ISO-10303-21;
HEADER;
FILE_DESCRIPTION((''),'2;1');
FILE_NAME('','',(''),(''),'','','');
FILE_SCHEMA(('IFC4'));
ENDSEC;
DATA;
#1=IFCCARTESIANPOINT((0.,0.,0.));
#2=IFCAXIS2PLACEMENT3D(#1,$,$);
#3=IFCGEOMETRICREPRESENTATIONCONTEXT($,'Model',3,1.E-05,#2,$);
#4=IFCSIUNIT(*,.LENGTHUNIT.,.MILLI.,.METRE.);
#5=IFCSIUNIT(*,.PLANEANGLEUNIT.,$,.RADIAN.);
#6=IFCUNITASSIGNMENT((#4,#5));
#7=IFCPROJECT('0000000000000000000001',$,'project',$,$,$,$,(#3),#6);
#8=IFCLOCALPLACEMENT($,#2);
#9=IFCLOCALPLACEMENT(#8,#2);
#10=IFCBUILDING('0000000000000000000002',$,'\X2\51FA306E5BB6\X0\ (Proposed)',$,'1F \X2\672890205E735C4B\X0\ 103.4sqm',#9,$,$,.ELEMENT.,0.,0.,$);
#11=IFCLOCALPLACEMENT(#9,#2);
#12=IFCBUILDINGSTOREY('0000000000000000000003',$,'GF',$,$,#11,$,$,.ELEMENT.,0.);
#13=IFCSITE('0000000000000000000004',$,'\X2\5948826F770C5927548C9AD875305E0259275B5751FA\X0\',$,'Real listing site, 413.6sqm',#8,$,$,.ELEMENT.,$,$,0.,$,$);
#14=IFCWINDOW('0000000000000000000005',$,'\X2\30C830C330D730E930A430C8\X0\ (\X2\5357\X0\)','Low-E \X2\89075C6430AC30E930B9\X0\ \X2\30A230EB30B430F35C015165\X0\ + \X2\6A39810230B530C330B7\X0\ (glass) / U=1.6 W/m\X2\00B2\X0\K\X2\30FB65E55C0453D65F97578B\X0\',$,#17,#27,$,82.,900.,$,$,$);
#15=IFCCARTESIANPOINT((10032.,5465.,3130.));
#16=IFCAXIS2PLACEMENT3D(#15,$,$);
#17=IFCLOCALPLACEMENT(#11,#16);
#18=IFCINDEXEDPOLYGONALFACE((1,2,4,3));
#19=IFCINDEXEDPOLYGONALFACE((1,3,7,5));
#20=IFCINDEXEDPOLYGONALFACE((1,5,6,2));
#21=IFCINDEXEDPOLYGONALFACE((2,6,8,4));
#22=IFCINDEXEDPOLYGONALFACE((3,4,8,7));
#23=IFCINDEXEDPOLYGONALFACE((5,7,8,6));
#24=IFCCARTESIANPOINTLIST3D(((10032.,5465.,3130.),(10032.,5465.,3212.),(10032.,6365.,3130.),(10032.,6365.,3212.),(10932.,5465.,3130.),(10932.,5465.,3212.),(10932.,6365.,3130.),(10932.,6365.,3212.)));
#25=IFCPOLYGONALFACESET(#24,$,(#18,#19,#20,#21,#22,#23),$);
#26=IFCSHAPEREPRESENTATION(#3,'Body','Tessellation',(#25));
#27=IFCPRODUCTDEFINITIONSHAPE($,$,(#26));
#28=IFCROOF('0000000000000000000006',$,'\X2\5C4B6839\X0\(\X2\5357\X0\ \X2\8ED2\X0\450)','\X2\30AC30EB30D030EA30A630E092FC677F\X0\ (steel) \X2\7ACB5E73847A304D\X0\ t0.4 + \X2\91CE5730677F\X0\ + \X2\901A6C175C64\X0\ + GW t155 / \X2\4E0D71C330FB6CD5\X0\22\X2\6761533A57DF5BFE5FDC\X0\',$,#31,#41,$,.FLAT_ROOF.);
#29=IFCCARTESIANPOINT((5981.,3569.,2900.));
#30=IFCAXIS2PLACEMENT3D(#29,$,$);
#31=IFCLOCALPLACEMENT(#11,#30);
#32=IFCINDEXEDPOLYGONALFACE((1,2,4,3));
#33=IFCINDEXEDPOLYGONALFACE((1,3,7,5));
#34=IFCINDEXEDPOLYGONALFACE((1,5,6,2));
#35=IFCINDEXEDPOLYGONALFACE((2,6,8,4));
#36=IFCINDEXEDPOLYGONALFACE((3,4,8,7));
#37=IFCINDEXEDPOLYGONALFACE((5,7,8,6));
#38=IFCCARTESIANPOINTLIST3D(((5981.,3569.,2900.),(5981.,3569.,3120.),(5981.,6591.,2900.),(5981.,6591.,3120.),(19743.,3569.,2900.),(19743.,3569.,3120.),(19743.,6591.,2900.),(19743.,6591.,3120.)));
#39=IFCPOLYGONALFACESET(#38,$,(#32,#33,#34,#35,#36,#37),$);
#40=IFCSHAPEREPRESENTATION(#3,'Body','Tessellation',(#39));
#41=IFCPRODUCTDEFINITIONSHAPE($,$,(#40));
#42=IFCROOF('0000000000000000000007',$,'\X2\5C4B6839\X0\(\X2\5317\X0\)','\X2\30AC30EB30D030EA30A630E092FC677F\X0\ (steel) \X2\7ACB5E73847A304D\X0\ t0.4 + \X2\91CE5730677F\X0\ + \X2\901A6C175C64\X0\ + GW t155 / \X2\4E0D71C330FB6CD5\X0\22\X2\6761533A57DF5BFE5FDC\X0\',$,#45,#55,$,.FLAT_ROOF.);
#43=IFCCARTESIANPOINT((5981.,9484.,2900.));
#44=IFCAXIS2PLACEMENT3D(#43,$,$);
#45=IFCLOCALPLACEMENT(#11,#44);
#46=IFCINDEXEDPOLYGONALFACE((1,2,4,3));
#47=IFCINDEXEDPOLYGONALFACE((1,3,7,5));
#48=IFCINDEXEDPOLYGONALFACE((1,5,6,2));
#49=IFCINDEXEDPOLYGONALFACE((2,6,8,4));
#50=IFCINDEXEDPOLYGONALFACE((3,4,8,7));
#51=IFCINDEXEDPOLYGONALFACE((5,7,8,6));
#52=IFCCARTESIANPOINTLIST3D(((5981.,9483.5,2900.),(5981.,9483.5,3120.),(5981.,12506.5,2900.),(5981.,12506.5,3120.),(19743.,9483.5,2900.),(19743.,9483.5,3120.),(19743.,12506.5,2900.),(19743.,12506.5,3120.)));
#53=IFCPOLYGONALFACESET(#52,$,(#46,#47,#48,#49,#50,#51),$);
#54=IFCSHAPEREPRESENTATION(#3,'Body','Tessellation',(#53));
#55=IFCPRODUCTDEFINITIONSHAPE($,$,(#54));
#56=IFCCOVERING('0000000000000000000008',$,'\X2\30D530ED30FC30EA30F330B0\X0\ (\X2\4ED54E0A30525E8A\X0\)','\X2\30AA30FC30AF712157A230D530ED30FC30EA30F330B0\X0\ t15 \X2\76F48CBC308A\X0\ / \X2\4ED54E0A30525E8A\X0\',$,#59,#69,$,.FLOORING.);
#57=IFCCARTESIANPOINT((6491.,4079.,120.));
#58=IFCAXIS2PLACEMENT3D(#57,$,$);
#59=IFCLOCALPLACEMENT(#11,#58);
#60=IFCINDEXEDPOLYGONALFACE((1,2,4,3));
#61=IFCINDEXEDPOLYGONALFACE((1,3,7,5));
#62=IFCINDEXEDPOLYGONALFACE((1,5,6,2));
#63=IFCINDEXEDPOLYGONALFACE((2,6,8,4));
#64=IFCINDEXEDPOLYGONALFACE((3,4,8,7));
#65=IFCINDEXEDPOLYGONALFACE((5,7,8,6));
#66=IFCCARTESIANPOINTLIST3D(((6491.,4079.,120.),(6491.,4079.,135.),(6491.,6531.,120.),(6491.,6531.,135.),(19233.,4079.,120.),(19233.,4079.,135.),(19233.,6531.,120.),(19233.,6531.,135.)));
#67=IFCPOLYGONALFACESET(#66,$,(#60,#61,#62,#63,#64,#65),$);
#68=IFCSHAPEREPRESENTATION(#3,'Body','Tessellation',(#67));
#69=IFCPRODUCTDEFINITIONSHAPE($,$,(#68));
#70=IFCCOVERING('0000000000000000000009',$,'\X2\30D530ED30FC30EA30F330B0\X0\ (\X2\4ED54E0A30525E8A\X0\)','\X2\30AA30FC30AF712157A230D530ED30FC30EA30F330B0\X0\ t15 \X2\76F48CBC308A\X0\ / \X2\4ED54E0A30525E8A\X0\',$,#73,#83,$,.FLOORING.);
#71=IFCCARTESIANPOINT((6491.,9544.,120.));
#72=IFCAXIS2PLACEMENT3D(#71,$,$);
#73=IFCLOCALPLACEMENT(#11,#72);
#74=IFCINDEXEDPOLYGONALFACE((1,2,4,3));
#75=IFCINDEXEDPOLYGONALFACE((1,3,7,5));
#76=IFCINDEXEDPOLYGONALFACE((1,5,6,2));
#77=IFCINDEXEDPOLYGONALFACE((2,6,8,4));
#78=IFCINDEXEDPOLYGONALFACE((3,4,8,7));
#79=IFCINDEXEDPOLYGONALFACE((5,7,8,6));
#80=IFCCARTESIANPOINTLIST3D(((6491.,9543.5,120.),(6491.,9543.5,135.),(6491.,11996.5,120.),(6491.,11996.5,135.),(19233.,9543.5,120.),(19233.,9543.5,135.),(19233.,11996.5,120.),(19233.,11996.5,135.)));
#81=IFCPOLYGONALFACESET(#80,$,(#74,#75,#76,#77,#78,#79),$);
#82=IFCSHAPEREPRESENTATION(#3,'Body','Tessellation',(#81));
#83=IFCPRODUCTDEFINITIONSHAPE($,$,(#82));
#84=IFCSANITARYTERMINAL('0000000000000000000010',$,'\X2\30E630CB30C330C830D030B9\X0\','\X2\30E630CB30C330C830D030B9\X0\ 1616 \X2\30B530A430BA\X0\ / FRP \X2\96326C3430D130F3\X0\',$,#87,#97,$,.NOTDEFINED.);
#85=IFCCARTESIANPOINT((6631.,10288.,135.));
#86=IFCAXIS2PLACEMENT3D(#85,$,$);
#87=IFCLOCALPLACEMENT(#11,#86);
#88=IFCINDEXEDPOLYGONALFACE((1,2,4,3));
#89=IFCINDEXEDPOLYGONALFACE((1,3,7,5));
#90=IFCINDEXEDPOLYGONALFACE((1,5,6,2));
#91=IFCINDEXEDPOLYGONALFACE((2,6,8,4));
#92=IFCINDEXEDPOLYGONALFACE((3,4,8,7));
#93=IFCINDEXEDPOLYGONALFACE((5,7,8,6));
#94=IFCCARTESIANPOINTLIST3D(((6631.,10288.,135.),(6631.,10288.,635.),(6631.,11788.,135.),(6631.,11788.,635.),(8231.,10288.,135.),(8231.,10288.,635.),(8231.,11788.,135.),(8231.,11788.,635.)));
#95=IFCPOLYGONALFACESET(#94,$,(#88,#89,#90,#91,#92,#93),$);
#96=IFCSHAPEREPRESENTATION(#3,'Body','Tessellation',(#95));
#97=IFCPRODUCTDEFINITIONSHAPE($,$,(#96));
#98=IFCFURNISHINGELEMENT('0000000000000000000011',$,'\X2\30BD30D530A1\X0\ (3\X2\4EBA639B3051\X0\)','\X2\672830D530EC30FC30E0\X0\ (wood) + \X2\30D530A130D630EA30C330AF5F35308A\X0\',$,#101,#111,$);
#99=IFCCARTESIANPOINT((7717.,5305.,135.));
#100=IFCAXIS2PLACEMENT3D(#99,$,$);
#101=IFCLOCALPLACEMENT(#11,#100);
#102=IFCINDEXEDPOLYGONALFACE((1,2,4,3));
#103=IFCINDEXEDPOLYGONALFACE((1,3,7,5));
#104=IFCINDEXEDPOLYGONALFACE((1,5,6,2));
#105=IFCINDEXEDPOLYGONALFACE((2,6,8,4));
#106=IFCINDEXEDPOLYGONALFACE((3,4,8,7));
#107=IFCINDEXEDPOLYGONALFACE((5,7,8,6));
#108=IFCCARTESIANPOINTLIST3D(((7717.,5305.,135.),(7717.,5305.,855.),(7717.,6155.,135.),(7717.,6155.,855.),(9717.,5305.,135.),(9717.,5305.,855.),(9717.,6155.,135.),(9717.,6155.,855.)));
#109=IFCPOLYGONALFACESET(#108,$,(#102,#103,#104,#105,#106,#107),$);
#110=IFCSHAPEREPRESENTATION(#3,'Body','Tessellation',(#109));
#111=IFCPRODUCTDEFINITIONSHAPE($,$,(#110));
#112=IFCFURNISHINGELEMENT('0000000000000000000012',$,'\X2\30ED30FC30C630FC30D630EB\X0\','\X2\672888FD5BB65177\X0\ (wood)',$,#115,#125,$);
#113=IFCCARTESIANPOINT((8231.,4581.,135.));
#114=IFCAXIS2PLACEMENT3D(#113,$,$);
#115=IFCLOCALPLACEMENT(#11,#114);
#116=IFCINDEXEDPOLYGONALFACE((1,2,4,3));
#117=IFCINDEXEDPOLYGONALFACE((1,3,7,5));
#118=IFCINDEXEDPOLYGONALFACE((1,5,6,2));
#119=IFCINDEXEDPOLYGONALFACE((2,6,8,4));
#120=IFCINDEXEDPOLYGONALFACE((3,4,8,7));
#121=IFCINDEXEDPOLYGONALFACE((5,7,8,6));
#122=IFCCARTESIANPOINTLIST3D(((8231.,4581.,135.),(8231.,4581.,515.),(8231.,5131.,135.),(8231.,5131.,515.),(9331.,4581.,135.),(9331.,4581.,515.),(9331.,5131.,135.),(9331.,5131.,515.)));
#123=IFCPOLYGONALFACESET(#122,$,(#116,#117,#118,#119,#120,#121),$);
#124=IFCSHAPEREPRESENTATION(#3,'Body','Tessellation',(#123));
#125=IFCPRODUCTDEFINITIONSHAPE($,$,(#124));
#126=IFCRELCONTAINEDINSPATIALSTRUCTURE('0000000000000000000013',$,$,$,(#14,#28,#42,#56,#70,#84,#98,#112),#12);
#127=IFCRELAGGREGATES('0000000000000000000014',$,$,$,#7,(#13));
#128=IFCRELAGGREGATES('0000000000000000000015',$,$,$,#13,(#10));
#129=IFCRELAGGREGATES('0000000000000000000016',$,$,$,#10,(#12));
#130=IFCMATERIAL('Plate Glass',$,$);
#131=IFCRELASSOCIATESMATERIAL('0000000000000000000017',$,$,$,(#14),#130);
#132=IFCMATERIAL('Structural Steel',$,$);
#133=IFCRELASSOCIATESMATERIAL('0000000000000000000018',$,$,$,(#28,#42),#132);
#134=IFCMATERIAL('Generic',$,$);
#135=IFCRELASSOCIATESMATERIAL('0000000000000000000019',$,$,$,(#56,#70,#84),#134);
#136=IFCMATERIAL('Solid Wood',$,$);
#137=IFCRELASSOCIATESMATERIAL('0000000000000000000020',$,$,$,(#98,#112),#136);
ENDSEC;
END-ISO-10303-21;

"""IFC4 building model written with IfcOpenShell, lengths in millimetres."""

from ifc_helpers import new_model, si_unit, frame, frame_2d, origin, place, context, project, spatial, rectangle, extrude, material, element, save


model = new_model("IFC4")

# Units and contexts
model_context = context("Model", 3, precision=1e-05, world=origin())
ifc_project = project(units=[si_unit("LENGTHUNIT", "METRE", prefix="MILLI"), si_unit("PLANEANGLEUNIT", "RADIAN")], contexts=[model_context])

# Site, building, storey
site_placement = place(None, origin())
site = spatial("IfcSite", under=ifc_project, at=site_placement, Name="奈良県大和高田市大字出", ObjectType="Real listing site, 413.6sqm", CompositionType="ELEMENT", RefElevation=0.0)
building_placement = place(site_placement, origin())
building = spatial("IfcBuilding", under=site, at=building_placement, Name="出の家 (Proposed)", ObjectType="1F 木造平屋 103.4sqm", CompositionType="ELEMENT", ElevationOfRefHeight=0.0, ElevationOfTerrain=0.0)
storey_placement = place(building_placement, origin())
storey = spatial("IfcBuildingStorey", under=building, at=storey_placement, Name="GF", CompositionType="ELEMENT", Elevation=0.0)

# Shared definitions
ifc_material_1 = material(Name="Solid Wood")

# Shared definitions
ifc_material_2 = material(Name="Plate Glass")

# Window
window_1_placement = place(storey_placement, frame((10032.0, 5465.0, 3130.0)))
element("IfcWindow", 1, at=window_1_placement, inside=storey, material=ifc_material_2, Name="トップライト (南)", Description="Low-E 複層ガラス アルゴン封入 + 樹脂サッシ (glass) / U=1.6 W/m²K・日射取得型", OverallHeight=82.0, OverallWidth=900.0, context=model_context, shape_type="SweptSolid", body=[
    extrude(rectangle(XDim=900.0, YDim=900.0, at=frame_2d((450.0, 450.0))), frame((10032.0, 5465.0, 3130.0)), (0.0, 0.0, 1.0), 82.0),
])

# Roofs
ifc_material_3 = material(Name="Structural Steel")
roof_1_placement = place(storey_placement, frame((5981.0, 3569.0, 2900.0)))
element("IfcRoof", 2, at=roof_1_placement, inside=storey, material=ifc_material_3, Name="屋根(南 軒450)", Description="ガルバリウム鋼板 (steel) 立平葺き t0.4 + 野地板 + 通気層 + GW t155 / 不燃・法22条区域対応", PredefinedType="FLAT_ROOF", context=model_context, shape_type="SweptSolid", body=[
    extrude(rectangle(XDim=13762.0, YDim=3022.0, at=frame_2d((6881.0, 1511.0))), frame((5981.0, 3569.0, 2900.0)), (0.0, 0.0, 1.0), 220.0),
])
roof_2_placement = place(storey_placement, frame((5981.0, 9484.0, 2900.0)))
element("IfcRoof", 3, at=roof_2_placement, inside=storey, material=ifc_material_3, Name="屋根(北)", Description="ガルバリウム鋼板 (steel) 立平葺き t0.4 + 野地板 + 通気層 + GW t155 / 不燃・法22条区域対応", PredefinedType="FLAT_ROOF", context=model_context, shape_type="SweptSolid", body=[
    extrude(rectangle(XDim=13762.0, YDim=3023.0, at=frame_2d((6881.0, 1511.0))), frame((5981.0, 9484.0, 2900.0)), (0.0, 0.0, 1.0), 220.0),
])

# Coverings
ifc_material_4 = material(Name="Generic")
covering_1_placement = place(storey_placement, frame((6491.0, 4079.0, 120.0)))
element("IfcCovering", 4, at=covering_1_placement, inside=storey, material=ifc_material_4, Name="フローリング (仕上げ床)", Description="オーク無垢フローリング t15 直貼り / 仕上げ床", PredefinedType="FLOORING", context=model_context, shape_type="SweptSolid", body=[
    extrude(rectangle(XDim=12742.0, YDim=2452.0, at=frame_2d((6371.0, 1226.0))), frame((6491.0, 4079.0, 120.0)), (0.0, 0.0, 1.0), 15.0),
])
covering_2_placement = place(storey_placement, frame((6491.0, 9544.0, 120.0)))
element("IfcCovering", 5, at=covering_2_placement, inside=storey, material=ifc_material_4, Name="フローリング (仕上げ床)", Description="オーク無垢フローリング t15 直貼り / 仕上げ床", PredefinedType="FLOORING", context=model_context, shape_type="SweptSolid", body=[
    extrude(rectangle(XDim=12742.0, YDim=2453.0, at=frame_2d((6371.0, 1226.0))), frame((6491.0, 9544.0, 120.0)), (0.0, 0.0, 1.0), 15.0),
])

# Sanitary terminal
sanitary_terminal_placement = place(storey_placement, frame((6631.0, 10288.0, 135.0)))
element("IfcSanitaryTerminal", 6, at=sanitary_terminal_placement, inside=storey, material=ifc_material_4, Name="ユニットバス", Description="ユニットバス 1616 サイズ / FRP 防水パン", PredefinedType="NOTDEFINED", context=model_context, shape_type="SweptSolid", body=[
    extrude(rectangle(XDim=1600.0, YDim=1500.0, at=frame_2d((800.0, 750.0))), frame((6631.0, 10288.0, 135.0)), (0.0, 0.0, 1.0), 500.0),
])

# Furnishing elements
furnishing_1_placement = place(storey_placement, frame((7717.0, 5305.0, 135.0)))
element("IfcFurnishingElement", 7, at=furnishing_1_placement, inside=storey, material=ifc_material_1, Name="ソファ (3人掛け)", Description="木フレーム (wood) + ファブリック張り", context=model_context, shape_type="SweptSolid", body=[
    extrude(rectangle(XDim=2000.0, YDim=850.0, at=frame_2d((1000.0, 425.0))), frame((7717.0, 5305.0, 135.0)), (0.0, 0.0, 1.0), 720.0),
])
furnishing_2_placement = place(storey_placement, frame((8231.0, 4581.0, 135.0)))
element("IfcFurnishingElement", 8, at=furnishing_2_placement, inside=storey, material=ifc_material_1, Name="ローテーブル", Description="木製家具 (wood)", context=model_context, shape_type="SweptSolid", body=[
    extrude(rectangle(XDim=1100.0, YDim=550.0, at=frame_2d((550.0, 275.0))), frame((8231.0, 4581.0, 135.0)), (0.0, 0.0, 1.0), 380.0),
])

save(model, "model.ifc")
